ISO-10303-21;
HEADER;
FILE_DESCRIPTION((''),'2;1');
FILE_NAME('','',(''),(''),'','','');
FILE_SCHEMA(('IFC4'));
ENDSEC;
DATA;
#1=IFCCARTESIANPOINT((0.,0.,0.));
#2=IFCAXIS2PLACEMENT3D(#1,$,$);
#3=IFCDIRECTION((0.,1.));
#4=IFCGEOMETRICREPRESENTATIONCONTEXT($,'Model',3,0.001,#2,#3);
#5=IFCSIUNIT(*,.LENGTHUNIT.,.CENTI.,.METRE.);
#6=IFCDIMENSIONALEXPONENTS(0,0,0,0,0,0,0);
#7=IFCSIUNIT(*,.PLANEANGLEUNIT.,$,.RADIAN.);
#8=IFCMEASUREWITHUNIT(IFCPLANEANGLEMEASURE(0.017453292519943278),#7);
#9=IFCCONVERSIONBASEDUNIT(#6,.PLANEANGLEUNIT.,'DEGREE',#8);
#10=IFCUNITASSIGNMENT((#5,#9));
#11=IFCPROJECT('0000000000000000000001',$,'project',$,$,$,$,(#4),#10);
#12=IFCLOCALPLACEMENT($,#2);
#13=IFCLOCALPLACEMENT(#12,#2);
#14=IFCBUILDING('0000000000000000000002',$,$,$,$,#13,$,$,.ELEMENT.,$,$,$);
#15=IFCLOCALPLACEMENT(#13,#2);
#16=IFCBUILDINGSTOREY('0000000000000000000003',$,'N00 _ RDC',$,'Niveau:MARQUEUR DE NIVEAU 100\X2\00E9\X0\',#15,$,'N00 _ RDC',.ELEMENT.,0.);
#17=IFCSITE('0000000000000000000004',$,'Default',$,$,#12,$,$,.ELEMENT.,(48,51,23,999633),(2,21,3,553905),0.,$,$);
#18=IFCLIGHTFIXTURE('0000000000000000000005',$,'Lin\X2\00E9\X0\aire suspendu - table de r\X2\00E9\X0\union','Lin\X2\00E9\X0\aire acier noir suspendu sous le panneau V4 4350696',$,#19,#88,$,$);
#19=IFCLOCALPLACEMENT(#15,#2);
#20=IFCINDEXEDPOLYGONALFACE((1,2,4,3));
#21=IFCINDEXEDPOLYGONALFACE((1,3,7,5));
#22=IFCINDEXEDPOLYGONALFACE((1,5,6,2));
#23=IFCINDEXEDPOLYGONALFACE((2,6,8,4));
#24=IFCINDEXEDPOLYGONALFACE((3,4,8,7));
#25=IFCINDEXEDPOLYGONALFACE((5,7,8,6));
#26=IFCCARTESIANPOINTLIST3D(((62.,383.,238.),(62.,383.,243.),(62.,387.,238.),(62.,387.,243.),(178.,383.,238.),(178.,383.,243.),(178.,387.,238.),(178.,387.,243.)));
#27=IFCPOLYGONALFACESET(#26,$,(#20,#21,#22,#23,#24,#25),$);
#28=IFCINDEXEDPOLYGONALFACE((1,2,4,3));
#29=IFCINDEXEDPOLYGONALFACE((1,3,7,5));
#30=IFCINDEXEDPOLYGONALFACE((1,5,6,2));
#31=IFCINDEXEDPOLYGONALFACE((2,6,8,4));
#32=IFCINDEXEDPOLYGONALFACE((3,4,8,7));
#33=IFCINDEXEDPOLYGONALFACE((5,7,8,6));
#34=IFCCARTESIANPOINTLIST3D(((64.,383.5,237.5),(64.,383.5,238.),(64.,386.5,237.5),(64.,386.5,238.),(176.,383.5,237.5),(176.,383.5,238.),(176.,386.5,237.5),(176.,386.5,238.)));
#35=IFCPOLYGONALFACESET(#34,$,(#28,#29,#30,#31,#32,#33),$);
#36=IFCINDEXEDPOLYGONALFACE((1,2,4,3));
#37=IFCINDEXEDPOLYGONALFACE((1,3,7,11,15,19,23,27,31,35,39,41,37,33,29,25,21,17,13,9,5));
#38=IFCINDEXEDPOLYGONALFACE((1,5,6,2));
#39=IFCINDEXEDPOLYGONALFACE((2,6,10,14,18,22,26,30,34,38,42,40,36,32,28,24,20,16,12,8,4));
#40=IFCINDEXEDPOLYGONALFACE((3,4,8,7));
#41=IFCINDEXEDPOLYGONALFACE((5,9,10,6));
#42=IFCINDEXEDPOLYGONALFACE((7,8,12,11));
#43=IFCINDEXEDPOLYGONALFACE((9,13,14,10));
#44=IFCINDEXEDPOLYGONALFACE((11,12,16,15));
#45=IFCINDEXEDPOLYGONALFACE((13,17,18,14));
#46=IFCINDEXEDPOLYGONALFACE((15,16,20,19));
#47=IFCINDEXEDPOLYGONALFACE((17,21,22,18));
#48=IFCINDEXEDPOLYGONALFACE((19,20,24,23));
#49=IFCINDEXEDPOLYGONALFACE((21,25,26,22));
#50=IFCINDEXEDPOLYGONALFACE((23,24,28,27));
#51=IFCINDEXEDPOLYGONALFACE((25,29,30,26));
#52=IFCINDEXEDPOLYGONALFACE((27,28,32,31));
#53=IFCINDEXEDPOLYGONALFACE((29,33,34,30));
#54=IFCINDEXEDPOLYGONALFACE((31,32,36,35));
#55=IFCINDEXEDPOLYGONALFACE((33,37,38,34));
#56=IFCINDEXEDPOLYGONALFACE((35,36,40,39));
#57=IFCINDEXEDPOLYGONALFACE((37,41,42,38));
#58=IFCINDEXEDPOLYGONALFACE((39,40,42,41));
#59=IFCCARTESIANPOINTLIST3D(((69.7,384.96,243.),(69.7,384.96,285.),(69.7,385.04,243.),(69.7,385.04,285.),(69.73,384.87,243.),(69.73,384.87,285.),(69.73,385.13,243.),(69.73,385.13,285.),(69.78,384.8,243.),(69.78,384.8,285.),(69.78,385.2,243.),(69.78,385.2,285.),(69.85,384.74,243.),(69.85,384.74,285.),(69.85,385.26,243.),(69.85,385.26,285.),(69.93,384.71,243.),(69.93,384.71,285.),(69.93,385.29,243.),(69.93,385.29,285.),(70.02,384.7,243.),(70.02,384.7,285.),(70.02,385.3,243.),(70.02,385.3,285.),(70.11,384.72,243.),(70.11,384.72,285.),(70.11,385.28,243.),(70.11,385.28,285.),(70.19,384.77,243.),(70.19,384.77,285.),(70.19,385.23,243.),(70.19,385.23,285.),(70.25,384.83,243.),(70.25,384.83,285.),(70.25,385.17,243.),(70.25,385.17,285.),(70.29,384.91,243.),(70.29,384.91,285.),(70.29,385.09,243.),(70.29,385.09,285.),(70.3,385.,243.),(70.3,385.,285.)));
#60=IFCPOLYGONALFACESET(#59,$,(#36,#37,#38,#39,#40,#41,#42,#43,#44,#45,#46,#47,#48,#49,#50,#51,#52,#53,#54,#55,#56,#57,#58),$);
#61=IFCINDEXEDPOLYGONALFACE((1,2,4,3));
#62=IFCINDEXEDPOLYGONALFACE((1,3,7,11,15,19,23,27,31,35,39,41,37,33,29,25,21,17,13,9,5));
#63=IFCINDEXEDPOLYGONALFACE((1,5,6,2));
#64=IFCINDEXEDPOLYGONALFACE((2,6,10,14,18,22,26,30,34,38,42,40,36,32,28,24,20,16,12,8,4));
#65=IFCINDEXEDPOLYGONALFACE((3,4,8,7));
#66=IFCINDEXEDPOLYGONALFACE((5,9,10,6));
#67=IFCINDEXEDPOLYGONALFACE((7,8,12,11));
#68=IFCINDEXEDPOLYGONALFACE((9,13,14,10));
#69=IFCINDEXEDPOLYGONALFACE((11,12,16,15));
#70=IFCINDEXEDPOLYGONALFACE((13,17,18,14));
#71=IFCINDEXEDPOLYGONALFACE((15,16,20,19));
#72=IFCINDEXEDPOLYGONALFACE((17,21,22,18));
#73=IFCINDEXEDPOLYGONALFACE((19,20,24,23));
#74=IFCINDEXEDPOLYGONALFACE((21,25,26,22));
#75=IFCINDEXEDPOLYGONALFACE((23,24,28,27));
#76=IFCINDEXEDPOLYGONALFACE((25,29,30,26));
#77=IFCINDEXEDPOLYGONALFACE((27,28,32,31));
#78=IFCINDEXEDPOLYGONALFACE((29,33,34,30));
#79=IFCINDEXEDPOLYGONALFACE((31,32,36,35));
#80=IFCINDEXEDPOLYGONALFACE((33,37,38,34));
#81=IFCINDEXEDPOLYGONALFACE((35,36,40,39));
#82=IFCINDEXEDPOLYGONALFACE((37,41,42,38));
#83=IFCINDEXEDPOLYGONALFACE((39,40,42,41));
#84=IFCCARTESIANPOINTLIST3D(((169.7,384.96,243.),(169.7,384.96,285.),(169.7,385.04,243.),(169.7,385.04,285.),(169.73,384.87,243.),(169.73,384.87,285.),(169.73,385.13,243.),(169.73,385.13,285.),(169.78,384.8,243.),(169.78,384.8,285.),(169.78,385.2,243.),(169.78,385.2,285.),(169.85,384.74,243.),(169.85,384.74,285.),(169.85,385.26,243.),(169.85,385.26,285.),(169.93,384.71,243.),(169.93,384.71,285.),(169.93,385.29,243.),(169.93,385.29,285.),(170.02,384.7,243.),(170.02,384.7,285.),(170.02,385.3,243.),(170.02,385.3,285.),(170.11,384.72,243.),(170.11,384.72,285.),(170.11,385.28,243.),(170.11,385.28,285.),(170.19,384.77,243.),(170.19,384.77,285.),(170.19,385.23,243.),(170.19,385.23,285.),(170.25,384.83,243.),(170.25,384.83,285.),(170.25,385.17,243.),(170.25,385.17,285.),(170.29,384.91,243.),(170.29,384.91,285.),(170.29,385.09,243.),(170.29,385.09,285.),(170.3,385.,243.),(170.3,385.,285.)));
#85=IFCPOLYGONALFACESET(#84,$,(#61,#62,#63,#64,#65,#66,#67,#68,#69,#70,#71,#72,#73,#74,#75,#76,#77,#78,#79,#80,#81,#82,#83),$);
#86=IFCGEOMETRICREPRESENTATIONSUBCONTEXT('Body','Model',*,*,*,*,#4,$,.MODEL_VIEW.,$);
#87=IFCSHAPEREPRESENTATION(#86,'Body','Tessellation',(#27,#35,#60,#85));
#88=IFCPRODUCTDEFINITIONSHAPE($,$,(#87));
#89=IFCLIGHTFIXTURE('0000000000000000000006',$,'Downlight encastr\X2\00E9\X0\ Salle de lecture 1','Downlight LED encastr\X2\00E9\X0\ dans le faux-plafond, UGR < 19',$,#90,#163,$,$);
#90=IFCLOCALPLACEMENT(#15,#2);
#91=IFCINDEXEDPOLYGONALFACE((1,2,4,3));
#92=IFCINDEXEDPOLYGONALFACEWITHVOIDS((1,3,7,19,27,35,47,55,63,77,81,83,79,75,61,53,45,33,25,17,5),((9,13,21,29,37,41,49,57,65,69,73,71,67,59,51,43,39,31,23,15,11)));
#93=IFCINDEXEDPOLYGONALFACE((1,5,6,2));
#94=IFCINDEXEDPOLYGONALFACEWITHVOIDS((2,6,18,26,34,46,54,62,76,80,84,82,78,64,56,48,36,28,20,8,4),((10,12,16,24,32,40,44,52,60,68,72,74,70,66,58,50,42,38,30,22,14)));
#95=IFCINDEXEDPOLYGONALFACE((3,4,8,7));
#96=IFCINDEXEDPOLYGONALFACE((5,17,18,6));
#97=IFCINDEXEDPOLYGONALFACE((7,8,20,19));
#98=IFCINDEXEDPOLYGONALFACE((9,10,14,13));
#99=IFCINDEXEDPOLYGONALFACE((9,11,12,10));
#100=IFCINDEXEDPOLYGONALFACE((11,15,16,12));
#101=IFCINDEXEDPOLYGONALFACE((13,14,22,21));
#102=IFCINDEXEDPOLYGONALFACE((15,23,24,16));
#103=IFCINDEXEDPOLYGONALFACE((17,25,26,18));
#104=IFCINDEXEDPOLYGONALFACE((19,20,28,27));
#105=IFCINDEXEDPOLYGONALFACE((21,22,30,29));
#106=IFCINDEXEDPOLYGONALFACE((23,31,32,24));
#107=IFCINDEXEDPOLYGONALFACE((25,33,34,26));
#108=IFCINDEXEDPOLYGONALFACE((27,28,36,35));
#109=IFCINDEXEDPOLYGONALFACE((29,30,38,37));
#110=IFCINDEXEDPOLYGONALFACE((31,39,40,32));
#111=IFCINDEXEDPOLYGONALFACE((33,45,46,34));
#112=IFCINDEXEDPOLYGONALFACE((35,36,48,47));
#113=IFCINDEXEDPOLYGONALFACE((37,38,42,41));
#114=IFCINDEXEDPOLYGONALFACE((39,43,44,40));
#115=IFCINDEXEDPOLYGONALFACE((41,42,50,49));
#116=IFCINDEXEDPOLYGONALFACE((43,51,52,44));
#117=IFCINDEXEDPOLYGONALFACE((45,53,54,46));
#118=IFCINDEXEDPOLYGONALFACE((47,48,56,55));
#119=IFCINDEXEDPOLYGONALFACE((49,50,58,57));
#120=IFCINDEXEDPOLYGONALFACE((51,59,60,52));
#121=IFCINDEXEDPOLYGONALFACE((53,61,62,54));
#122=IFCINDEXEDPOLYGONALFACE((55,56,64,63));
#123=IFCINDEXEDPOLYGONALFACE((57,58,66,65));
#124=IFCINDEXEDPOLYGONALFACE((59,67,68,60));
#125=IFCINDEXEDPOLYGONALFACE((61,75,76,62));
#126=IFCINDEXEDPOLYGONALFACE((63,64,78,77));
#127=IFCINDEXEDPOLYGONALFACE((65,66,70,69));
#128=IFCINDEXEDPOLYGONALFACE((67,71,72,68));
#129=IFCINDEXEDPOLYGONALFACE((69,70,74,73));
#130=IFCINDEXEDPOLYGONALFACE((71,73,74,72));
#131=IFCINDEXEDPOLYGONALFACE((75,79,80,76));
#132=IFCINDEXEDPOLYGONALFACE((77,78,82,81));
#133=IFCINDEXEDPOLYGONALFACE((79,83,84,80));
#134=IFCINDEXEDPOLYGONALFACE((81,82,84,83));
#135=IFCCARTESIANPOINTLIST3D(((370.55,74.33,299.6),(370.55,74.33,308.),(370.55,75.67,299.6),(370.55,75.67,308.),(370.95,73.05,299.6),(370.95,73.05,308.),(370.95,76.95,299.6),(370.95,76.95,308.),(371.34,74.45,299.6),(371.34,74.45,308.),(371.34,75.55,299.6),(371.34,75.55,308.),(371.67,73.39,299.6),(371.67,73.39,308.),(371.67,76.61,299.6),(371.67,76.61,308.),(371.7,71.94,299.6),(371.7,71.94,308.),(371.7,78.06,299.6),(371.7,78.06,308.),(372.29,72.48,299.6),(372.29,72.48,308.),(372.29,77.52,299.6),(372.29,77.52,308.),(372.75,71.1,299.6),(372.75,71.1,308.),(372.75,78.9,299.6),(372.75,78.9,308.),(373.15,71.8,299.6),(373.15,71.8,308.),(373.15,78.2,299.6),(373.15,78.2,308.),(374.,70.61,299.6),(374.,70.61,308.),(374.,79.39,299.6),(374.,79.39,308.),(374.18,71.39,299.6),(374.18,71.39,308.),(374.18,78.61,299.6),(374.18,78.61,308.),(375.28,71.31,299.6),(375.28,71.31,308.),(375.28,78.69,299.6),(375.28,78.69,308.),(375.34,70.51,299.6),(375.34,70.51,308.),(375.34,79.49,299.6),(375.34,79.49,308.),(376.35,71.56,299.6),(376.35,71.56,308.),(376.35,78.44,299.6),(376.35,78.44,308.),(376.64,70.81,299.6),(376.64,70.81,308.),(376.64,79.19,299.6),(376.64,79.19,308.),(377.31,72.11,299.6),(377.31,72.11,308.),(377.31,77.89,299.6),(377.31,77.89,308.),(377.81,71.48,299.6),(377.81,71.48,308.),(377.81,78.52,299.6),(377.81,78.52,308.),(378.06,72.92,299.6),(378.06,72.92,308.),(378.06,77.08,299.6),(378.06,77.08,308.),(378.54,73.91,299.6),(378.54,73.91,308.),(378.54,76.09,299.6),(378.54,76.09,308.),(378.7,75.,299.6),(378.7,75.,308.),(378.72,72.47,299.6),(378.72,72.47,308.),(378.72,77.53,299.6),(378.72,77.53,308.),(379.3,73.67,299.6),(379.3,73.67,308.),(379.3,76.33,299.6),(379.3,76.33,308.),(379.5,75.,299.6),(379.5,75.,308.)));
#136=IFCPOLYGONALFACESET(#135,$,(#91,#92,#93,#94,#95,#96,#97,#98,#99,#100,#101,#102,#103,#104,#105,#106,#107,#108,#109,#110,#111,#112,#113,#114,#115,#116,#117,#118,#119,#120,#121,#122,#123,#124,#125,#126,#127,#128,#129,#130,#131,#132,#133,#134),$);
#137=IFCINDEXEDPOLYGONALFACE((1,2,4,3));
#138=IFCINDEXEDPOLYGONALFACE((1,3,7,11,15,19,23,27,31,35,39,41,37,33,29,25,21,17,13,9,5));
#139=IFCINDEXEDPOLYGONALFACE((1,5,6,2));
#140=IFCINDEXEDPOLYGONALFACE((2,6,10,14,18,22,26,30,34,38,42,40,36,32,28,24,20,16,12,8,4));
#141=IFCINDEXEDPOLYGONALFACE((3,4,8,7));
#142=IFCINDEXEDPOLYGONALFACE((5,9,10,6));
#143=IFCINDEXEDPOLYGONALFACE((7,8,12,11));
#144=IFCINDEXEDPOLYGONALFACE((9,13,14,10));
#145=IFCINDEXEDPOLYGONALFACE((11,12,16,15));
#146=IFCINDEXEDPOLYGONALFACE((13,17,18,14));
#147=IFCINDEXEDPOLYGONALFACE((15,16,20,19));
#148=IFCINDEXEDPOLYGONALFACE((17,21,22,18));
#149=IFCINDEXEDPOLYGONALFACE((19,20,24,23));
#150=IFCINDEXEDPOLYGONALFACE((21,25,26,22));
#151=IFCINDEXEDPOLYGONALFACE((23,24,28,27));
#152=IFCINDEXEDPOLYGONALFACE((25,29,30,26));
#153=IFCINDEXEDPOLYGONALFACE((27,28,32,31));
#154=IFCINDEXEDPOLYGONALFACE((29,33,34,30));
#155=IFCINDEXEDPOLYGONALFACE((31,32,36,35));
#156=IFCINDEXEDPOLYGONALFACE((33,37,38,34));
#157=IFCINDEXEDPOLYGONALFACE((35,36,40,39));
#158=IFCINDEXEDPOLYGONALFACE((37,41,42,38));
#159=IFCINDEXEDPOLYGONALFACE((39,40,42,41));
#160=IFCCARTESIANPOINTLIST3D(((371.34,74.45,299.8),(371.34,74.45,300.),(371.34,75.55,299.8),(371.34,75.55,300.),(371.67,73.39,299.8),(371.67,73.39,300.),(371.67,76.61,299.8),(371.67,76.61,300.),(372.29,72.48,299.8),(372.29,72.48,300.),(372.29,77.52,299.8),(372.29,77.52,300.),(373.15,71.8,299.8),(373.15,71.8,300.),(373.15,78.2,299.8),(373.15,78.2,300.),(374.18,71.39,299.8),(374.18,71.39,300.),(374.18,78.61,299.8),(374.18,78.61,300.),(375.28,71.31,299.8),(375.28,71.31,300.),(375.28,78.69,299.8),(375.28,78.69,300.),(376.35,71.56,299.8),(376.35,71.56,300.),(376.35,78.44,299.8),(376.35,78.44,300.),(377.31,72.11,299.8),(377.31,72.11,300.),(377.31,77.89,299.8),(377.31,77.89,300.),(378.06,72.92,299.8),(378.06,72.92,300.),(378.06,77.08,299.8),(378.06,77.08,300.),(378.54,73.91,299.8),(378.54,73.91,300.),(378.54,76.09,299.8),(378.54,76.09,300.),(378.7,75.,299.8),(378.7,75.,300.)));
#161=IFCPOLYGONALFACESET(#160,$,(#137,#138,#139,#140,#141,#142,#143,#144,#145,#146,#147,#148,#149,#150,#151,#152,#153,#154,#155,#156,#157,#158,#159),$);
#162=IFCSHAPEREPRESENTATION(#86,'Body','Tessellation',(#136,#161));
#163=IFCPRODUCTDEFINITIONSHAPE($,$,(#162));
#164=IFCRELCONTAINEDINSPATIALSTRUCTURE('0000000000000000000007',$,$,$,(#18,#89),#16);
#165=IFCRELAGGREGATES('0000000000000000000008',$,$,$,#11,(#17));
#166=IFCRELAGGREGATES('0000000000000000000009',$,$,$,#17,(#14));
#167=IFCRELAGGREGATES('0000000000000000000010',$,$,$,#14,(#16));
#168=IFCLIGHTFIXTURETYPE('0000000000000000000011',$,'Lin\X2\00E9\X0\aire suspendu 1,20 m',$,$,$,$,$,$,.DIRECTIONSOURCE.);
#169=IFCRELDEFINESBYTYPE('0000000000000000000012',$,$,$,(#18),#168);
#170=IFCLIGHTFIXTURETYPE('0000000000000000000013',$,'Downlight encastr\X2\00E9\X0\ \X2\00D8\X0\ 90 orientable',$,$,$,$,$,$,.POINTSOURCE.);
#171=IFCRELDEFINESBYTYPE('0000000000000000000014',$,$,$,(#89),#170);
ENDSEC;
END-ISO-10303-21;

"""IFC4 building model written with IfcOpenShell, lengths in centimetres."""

from ifc_helpers import new_model, entity, si_unit, converted_unit, direction, frame, frame_2d, origin, origin_with_axes, place, context, subcontext, project, spatial, rectangle, circle, hollow_circle, extrude, type_object, element, save


model = new_model("IFC4")

# Units and contexts
model_context = context("Model", 3, precision=0.001, world=origin(), true_north=direction((0.0, 1.0)))
body_context = subcontext(model_context, "Body", "Model", "MODEL_VIEW")
ifc_project = project(units=[si_unit("LENGTHUNIT", "METRE", prefix="CENTI"), converted_unit("PLANEANGLEUNIT", "DEGREE", entity("IfcPlaneAngleMeasure", 0.017453292519943278), si_unit("PLANEANGLEUNIT", "RADIAN"), dimensions=[0, 0, 0, 0, 0, 0, 0])], contexts=[model_context])

# Site, building, storey
site_placement = place(None, origin())
site = spatial("IfcSite", under=ifc_project, at=site_placement, Name="Default", CompositionType="ELEMENT", RefLatitude=(48, 51, 23, 999633), RefLongitude=(2, 21, 3, 553905), RefElevation=0.0)
building_placement = place(site_placement, origin())
building = spatial("IfcBuilding", under=site, at=building_placement, CompositionType="ELEMENT")
storey_placement = place(building_placement, origin())
storey = spatial("IfcBuildingStorey", under=building, at=storey_placement, Name="N00 _ RDC", ObjectType="Niveau:MARQUEUR DE NIVEAU 100é", LongName="N00 _ RDC", CompositionType="ELEMENT", Elevation=0.0)

# Light fixtures
light_fixture_type_1 = type_object("IfcLightFixtureType", Name="Linéaire suspendu 1,20 m", PredefinedType="DIRECTIONSOURCE")
light_fixture_1_placement = place(storey_placement, origin_with_axes())
element("IfcLightFixture", 1, at=light_fixture_1_placement, inside=storey, type_object=light_fixture_type_1, Name="Linéaire suspendu - table de réunion", Description="Linéaire acier noir suspendu sous le panneau V4 4350696", context=body_context, shape_type="SweptSolid", body=[
    extrude(rectangle(XDim=116.0, YDim=4.0, at=frame_2d((120.0, 385.0))), frame((0.0, 0.0, 238.0)), (0.0, 0.0, 1.0), 5.0),
    extrude(rectangle(XDim=112.0, YDim=3.0, at=frame_2d((120.0, 385.0))), frame((0.0, 0.0, 237.5)), (0.0, 0.0, 1.0), 0.5),
    extrude(circle(Radius=0.3, at=frame_2d((70.0, 385.0))), frame((0.0, 0.0, 243.0)), (0.0, 0.0, 1.0), 42.0),
    extrude(circle(Radius=0.3, at=frame_2d((170.0, 385.0))), frame((0.0, 0.0, 243.0)), (0.0, 0.0, 1.0), 42.0),
])
light_fixture_type_2 = type_object("IfcLightFixtureType", Name="Downlight encastré Ø 90 orientable", PredefinedType="POINTSOURCE")
light_fixture_2_placement = place(storey_placement, origin_with_axes())
element("IfcLightFixture", 2, at=light_fixture_2_placement, inside=storey, type_object=light_fixture_type_2, Name="Downlight encastré Salle de lecture 1", Description="Downlight LED encastré dans le faux-plafond, UGR < 19", context=body_context, shape_type="SweptSolid", body=[
    extrude(hollow_circle(Radius=4.5, WallThickness=0.8, at=frame_2d((375.0, 75.0))), frame((0.0, 0.0, 299.6)), (0.0, 0.0, 1.0), 8.4),
    extrude(circle(Radius=3.7, at=frame_2d((375.0, 75.0))), frame((0.0, 0.0, 299.8)), (0.0, 0.0, 1.0), 0.2),
])

save(model, "model.ifc")
